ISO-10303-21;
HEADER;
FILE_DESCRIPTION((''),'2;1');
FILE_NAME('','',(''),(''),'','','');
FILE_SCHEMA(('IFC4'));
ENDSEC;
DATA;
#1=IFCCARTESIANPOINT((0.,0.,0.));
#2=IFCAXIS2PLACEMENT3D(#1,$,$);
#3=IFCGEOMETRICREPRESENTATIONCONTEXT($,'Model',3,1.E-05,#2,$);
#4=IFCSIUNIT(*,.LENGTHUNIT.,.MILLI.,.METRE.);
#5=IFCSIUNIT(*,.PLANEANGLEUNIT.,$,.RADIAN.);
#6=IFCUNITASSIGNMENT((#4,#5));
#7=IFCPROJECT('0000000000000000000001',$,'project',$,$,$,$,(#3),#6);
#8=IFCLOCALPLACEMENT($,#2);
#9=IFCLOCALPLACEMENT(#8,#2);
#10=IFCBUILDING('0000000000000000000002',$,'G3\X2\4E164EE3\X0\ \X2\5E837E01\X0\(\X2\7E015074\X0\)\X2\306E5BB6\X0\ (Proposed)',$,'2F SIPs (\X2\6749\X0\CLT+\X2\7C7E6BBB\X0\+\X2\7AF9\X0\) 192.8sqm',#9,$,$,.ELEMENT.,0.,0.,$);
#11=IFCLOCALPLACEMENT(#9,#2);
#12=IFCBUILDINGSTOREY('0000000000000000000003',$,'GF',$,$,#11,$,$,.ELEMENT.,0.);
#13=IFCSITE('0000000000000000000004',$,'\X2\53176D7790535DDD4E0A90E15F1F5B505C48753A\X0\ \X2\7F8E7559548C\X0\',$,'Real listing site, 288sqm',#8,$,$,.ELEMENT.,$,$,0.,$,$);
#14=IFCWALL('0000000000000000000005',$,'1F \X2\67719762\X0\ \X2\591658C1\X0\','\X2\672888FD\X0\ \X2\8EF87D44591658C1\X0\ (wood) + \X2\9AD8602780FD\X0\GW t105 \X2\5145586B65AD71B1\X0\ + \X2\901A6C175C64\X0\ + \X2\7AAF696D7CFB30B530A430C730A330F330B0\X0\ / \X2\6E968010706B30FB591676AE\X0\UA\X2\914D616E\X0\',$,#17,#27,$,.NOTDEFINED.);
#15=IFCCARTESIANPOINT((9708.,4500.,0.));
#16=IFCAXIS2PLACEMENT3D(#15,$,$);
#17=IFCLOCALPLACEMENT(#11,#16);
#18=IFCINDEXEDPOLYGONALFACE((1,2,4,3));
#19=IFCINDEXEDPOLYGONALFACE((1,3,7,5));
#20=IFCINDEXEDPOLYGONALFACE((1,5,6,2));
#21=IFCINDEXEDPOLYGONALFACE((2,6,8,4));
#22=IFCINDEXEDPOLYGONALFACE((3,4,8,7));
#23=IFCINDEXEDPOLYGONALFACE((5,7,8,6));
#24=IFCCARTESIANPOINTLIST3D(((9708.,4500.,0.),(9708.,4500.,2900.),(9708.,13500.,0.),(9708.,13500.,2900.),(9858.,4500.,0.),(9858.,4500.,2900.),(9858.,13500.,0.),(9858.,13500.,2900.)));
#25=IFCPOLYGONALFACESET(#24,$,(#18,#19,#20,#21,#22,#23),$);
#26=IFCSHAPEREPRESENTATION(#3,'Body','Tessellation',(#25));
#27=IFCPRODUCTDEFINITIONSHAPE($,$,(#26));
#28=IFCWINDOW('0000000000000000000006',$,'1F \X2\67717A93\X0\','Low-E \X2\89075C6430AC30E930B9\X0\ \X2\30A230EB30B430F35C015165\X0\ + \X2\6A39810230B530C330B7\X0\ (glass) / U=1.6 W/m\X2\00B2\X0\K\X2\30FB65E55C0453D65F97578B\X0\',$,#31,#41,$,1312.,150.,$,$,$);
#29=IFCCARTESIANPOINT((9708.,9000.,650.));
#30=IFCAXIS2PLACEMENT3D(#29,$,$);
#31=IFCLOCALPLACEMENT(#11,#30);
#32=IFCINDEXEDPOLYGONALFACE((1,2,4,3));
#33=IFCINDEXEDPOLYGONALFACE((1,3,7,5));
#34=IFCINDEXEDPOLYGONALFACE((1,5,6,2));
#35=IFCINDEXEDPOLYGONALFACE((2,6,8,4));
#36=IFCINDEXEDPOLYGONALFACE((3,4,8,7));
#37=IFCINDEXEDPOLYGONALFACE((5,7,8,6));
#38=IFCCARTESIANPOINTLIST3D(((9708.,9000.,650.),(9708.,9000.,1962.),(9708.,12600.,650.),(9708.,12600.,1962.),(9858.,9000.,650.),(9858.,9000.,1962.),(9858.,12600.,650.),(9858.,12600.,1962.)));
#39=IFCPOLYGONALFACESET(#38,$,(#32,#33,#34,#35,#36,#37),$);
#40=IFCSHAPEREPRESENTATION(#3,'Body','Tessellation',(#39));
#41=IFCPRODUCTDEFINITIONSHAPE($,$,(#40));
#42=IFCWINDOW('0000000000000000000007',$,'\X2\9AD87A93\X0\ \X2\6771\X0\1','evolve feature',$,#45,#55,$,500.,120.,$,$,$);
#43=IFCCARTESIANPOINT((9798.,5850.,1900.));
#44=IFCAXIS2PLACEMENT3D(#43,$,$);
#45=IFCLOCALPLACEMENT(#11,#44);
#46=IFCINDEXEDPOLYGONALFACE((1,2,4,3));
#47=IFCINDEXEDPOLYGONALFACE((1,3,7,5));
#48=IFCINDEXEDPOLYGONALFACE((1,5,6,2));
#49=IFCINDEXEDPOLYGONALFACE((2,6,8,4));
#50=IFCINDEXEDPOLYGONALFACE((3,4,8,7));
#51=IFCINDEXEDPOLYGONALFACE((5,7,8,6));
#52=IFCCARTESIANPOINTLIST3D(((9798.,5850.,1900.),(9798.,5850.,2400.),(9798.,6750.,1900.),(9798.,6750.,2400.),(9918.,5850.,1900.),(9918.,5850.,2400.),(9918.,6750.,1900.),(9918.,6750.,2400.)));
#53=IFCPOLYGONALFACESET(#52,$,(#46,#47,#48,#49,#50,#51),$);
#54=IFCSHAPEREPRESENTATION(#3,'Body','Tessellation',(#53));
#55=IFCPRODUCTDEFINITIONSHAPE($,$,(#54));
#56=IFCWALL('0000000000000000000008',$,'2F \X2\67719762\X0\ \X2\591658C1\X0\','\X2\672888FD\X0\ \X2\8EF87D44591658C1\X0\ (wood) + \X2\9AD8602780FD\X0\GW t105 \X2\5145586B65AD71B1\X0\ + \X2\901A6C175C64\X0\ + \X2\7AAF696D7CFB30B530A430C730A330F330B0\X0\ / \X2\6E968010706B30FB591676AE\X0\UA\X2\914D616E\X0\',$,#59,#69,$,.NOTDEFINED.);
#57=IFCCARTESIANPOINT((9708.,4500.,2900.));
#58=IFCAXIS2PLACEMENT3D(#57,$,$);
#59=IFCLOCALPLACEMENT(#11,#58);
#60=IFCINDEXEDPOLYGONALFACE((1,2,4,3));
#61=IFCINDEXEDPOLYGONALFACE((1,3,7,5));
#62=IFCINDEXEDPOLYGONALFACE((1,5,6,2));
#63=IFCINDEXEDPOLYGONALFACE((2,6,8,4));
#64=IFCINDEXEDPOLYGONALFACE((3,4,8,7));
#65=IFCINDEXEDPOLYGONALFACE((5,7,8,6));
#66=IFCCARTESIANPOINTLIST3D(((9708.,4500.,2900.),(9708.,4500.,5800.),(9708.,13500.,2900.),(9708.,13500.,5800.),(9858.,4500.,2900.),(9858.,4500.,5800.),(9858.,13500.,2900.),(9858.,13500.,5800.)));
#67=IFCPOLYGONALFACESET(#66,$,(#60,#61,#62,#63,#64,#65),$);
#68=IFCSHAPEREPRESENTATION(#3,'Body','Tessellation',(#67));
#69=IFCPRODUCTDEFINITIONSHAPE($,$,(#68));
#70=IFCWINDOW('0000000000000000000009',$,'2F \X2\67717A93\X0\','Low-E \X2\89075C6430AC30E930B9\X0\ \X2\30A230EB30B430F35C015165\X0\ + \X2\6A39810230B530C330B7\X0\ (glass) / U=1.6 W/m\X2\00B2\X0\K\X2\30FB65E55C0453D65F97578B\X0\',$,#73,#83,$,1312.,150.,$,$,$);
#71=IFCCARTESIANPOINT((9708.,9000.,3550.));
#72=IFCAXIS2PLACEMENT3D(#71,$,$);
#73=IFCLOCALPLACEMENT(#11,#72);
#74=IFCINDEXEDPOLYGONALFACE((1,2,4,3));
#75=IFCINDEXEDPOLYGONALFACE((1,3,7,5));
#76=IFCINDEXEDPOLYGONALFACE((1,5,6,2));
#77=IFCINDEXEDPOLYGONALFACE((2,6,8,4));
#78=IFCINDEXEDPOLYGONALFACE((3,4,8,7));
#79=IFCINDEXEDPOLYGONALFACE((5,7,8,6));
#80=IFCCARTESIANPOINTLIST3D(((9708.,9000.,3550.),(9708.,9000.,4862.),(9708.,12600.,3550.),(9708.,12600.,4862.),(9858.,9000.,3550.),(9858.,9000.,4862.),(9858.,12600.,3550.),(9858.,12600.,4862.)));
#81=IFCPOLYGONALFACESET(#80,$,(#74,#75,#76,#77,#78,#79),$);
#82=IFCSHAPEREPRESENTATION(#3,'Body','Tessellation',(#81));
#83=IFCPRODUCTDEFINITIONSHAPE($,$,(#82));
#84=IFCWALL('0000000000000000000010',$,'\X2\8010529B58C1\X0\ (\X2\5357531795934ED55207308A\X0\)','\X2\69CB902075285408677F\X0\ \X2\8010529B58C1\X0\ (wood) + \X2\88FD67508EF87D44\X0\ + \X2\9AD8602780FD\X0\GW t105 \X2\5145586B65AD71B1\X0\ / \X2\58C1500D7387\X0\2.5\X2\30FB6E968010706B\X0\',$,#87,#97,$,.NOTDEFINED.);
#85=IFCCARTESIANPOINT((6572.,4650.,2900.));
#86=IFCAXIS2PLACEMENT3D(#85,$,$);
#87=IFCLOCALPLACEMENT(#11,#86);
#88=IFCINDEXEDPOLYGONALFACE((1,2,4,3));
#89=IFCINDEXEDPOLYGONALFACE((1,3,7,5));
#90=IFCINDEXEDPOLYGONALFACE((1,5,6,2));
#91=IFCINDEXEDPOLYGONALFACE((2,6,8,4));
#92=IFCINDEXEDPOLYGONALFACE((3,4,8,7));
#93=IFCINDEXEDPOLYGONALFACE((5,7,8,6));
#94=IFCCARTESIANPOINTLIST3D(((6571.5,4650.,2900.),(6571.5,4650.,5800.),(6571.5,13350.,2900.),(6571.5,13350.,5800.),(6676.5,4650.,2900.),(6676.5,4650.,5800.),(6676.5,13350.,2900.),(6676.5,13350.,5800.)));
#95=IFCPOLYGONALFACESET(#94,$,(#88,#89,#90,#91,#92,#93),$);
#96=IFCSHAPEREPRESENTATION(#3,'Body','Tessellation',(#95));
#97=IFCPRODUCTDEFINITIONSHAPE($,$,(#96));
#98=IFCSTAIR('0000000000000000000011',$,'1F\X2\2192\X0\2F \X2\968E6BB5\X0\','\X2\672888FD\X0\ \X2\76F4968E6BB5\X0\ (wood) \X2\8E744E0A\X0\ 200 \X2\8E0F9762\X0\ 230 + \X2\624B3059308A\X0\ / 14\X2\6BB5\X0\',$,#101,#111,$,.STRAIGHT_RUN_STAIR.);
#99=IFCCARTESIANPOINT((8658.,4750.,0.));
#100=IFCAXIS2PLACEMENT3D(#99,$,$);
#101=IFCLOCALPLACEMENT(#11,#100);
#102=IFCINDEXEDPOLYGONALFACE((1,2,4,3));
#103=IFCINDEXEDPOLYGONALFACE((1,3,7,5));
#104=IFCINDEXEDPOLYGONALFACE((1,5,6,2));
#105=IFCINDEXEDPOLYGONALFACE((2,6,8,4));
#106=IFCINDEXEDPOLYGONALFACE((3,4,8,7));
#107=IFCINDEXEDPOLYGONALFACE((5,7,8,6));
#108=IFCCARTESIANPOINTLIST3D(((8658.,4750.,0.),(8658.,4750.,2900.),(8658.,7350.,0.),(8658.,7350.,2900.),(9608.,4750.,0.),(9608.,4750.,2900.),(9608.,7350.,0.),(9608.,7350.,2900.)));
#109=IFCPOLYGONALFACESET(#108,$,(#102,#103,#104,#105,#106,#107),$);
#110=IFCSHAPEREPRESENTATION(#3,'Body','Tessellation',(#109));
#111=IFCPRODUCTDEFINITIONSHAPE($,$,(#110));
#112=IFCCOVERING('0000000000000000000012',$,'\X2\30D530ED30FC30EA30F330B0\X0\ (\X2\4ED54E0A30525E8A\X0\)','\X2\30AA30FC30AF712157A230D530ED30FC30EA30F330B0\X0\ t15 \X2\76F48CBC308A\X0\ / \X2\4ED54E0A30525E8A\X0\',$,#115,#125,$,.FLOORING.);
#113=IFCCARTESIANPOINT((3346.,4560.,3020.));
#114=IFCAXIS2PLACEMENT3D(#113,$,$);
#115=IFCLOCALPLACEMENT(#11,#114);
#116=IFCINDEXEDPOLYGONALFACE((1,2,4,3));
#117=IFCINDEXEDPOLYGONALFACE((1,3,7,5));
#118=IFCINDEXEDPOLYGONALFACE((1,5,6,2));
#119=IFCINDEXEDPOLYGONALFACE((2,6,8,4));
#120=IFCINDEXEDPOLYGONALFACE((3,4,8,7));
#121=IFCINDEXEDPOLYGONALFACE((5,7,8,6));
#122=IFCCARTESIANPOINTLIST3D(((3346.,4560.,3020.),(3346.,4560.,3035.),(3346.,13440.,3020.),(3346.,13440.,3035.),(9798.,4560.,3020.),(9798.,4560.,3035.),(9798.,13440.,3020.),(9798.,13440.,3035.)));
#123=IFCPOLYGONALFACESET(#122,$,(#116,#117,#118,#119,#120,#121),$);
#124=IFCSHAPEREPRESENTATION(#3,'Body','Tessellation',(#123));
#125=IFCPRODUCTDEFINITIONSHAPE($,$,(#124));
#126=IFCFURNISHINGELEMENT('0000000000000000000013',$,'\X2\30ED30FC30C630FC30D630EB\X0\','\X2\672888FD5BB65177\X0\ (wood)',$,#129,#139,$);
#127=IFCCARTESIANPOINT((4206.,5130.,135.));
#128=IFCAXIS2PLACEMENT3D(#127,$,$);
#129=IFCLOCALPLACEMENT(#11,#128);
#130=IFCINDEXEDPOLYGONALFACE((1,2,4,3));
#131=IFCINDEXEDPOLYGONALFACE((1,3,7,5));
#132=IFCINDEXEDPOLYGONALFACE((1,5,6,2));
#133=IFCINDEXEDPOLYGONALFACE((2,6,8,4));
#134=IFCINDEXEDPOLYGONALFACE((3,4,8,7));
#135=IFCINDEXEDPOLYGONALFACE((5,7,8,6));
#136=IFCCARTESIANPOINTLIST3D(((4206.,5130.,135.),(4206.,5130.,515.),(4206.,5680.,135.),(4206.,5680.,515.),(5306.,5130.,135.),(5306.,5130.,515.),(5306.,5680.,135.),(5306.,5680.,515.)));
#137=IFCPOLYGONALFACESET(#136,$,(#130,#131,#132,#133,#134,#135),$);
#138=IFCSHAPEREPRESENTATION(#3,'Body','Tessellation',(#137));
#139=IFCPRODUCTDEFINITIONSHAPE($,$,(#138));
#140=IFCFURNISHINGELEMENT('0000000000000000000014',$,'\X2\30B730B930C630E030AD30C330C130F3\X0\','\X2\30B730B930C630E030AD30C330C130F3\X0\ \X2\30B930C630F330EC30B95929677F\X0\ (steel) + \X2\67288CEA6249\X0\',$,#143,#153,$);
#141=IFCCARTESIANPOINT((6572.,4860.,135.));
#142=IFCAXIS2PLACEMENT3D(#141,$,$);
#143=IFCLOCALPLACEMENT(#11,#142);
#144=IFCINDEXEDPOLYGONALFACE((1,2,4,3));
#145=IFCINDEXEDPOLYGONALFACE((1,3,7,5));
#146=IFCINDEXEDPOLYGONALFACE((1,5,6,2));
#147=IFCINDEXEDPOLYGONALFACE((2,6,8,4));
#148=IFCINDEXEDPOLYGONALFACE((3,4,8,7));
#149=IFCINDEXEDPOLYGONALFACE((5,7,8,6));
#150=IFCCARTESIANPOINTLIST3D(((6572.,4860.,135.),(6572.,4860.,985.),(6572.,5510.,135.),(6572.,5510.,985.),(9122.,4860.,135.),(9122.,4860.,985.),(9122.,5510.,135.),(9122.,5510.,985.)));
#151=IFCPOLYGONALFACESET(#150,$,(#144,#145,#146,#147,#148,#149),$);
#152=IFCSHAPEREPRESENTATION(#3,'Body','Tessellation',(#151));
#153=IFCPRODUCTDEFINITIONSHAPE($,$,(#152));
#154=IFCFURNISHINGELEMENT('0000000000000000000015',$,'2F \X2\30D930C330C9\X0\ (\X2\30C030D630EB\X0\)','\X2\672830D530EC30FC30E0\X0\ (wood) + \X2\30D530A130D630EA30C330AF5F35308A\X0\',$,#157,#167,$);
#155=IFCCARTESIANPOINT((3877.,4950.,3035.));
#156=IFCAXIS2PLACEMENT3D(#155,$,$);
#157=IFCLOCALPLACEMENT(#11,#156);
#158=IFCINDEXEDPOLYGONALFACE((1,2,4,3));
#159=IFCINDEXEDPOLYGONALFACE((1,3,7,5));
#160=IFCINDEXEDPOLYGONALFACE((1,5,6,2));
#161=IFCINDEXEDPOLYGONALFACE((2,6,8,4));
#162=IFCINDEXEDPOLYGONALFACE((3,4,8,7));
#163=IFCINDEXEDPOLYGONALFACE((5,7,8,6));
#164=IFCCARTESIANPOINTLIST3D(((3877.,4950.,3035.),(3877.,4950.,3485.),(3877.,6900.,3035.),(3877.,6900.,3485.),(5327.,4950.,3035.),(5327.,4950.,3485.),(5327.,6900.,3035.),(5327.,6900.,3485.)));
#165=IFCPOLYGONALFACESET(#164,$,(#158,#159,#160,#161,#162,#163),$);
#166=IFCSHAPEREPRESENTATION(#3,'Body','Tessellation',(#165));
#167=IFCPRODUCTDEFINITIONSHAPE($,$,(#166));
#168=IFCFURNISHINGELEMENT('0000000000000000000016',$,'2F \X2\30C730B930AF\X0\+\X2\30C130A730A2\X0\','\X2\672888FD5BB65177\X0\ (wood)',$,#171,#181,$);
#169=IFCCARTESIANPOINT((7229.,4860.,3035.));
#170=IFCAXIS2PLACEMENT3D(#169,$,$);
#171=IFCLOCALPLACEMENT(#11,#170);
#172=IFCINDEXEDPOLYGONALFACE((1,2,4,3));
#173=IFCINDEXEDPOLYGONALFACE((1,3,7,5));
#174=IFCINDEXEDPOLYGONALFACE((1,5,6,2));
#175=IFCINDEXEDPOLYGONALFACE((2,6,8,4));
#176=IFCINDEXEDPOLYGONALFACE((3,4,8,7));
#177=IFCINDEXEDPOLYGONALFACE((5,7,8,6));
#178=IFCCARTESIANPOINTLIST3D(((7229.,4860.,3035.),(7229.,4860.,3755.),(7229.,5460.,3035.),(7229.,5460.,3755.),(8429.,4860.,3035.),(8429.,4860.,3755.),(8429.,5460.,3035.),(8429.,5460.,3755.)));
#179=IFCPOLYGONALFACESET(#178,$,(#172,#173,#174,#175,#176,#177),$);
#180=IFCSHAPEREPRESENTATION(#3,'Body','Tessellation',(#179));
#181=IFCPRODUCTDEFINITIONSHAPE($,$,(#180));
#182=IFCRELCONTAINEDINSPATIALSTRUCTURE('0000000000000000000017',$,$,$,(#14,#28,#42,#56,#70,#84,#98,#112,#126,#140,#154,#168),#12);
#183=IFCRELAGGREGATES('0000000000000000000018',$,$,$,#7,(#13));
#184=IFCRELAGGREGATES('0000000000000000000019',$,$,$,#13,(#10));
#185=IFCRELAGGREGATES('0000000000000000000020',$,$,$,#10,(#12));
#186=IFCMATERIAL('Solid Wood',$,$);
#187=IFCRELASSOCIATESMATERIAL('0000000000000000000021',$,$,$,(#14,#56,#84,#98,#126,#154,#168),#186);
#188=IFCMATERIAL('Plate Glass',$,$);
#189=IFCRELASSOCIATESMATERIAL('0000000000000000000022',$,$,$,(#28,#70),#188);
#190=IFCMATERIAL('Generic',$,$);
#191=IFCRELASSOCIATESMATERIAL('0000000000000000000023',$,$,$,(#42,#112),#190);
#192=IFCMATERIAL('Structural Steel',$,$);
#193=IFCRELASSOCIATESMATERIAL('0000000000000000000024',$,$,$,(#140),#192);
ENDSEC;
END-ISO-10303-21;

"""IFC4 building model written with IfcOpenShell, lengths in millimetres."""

from ifc_helpers import new_model, si_unit, frame, frame_2d, origin, place, context, project, spatial, rectangle, extrude, material, element, fill, save


model = new_model("IFC4")

# Units and contexts
model_context = context("Model", 3, precision=1e-05, world=origin())
ifc_project = project(units=[si_unit("LENGTHUNIT", "METRE", prefix="MILLI"), si_unit("PLANEANGLEUNIT", "RADIAN")], contexts=[model_context])

# Site, building, storey
site_placement = place(None, origin())
site = spatial("IfcSite", under=ifc_project, at=site_placement, Name="北海道川上郡弟子屈町 美留和", ObjectType="Real listing site, 288sqm", CompositionType="ELEMENT", RefElevation=0.0)
building_placement = place(site_placement, origin())
building = spatial("IfcBuilding", under=site, at=building_placement, Name="G3世代 広縁(縁側)の家 (Proposed)", ObjectType="2F SIPs (杉CLT+籾殻+竹) 192.8sqm", CompositionType="ELEMENT", ElevationOfRefHeight=0.0, ElevationOfTerrain=0.0)
storey_placement = place(building_placement, origin())
storey = spatial("IfcBuildingStorey", under=building, at=storey_placement, Name="GF", CompositionType="ELEMENT", Elevation=0.0)

# Shared definitions
ifc_material_1 = material(Name="Solid Wood")

# Wall, openings, windows
wall_1_placement = place(storey_placement, frame((9708.0, 4500.0, 0.0)))
wall_1 = element("IfcWall", 1, at=wall_1_placement, inside=storey, material=ifc_material_1, Name="1F 東面 外壁", Description="木製 軸組外壁 (wood) + 高性能GW t105 充填断熱 + 通気層 + 窯業系サイディング / 準耐火・外皮UA配慮", PredefinedType="NOTDEFINED", context=model_context, shape_type="SweptSolid", body=[
    extrude(rectangle(XDim=150.0, YDim=9000.0, at=frame_2d((75.0, 4500.0))), frame((9708.0, 4500.0, 0.0)), (0.0, 0.0, 1.0), 2900.0),
])
opening_1_placement = place(storey_placement, frame((9708.0, 9000.0, 650.0)))
opening_1 = element("IfcOpeningElement", 2, at=opening_1_placement, cuts=wall_1, PredefinedType="NOTDEFINED", context=model_context, shape_type="SweptSolid", body=[
    extrude(rectangle(XDim=150.0, YDim=3600.0, at=frame_2d((75.0, 1800.0))), frame((9708.0, 9000.0, 650.0)), (0.0, 0.0, 1.0), 1312.0),
])
opening_2_placement = place(storey_placement, frame((9798.0, 5850.0, 1900.0)))
opening_2 = element("IfcOpeningElement", 3, at=opening_2_placement, cuts=wall_1, PredefinedType="NOTDEFINED", context=model_context, shape_type="SweptSolid", body=[
    extrude(rectangle(XDim=120.0, YDim=900.0, at=frame_2d((60.0, 450.0))), frame((9798.0, 5850.0, 1900.0)), (0.0, 0.0, 1.0), 500.0),
])
ifc_material_2 = material(Name="Plate Glass")
window_1_placement = place(storey_placement, frame((9708.0, 9000.0, 650.0)))
window_1 = element("IfcWindow", 4, at=window_1_placement, inside=storey, material=ifc_material_2, Name="1F 東窓", Description="Low-E 複層ガラス アルゴン封入 + 樹脂サッシ (glass) / U=1.6 W/m²K・日射取得型", OverallHeight=1312.0, OverallWidth=150.0, context=model_context, shape_type="SweptSolid", body=[
    extrude(rectangle(XDim=150.0, YDim=3600.0, at=frame_2d((75.0, 1800.0))), frame((9708.0, 9000.0, 650.0)), (0.0, 0.0, 1.0), 1312.0),
])
fill(opening_1, window_1)
ifc_material_3 = material(Name="Generic")
window_2_placement = place(storey_placement, frame((9798.0, 5850.0, 1900.0)))
window_2 = element("IfcWindow", 5, at=window_2_placement, inside=storey, material=ifc_material_3, Name="高窓 東1", Description="evolve feature", OverallHeight=500.0, OverallWidth=120.0, context=model_context, shape_type="SweptSolid", body=[
    extrude(rectangle(XDim=120.0, YDim=900.0, at=frame_2d((60.0, 450.0))), frame((9798.0, 5850.0, 1900.0)), (0.0, 0.0, 1.0), 500.0),
])
fill(opening_2, window_2)

# Wall, opening, window
wall_2_placement = place(storey_placement, frame((9708.0, 4500.0, 2900.0)))
wall_2 = element("IfcWall", 6, at=wall_2_placement, inside=storey, material=ifc_material_1, Name="2F 東面 外壁", Description="木製 軸組外壁 (wood) + 高性能GW t105 充填断熱 + 通気層 + 窯業系サイディング / 準耐火・外皮UA配慮", PredefinedType="NOTDEFINED", context=model_context, shape_type="SweptSolid", body=[
    extrude(rectangle(XDim=150.0, YDim=9000.0, at=frame_2d((75.0, 4500.0))), frame((9708.0, 4500.0, 2900.0)), (0.0, 0.0, 1.0), 2900.0),
])
opening_3_placement = place(storey_placement, frame((9708.0, 9000.0, 3550.0)))
opening_3 = element("IfcOpeningElement", 7, at=opening_3_placement, cuts=wall_2, PredefinedType="NOTDEFINED", context=model_context, shape_type="SweptSolid", body=[
    extrude(rectangle(XDim=150.0, YDim=3600.0, at=frame_2d((75.0, 1800.0))), frame((9708.0, 9000.0, 3550.0)), (0.0, 0.0, 1.0), 1312.0),
])
window_3_placement = place(storey_placement, frame((9708.0, 9000.0, 3550.0)))
window_3 = element("IfcWindow", 8, at=window_3_placement, inside=storey, material=ifc_material_2, Name="2F 東窓", Description="Low-E 複層ガラス アルゴン封入 + 樹脂サッシ (glass) / U=1.6 W/m²K・日射取得型", OverallHeight=1312.0, OverallWidth=150.0, context=model_context, shape_type="SweptSolid", body=[
    extrude(rectangle(XDim=150.0, YDim=3600.0, at=frame_2d((75.0, 1800.0))), frame((9708.0, 9000.0, 3550.0)), (0.0, 0.0, 1.0), 1312.0),
])
fill(opening_3, window_3)

# Wall
wall_3_placement = place(storey_placement, frame((6572.0, 4650.0, 2900.0)))
element("IfcWall", 9, at=wall_3_placement, inside=storey, material=ifc_material_1, Name="耐力壁 (南北間仕切り)", Description="構造用合板 耐力壁 (wood) + 製材軸組 + 高性能GW t105 充填断熱 / 壁倍率2.5・準耐火", PredefinedType="NOTDEFINED", context=model_context, shape_type="SweptSolid", body=[
    extrude(rectangle(XDim=105.0, YDim=8700.0, at=frame_2d((52.0, 4350.0))), frame((6572.0, 4650.0, 2900.0)), (0.0, 0.0, 1.0), 2900.0),
])

# Stair
stair_placement = place(storey_placement, frame((8658.0, 4750.0, 0.0)))
element("IfcStair", 10, at=stair_placement, inside=storey, material=ifc_material_1, Name="1F→2F 階段", Description="木製 直階段 (wood) 蹴上 200 踏面 230 + 手すり / 14段", PredefinedType="STRAIGHT_RUN_STAIR", context=model_context, shape_type="SweptSolid", body=[
    extrude(rectangle(XDim=950.0, YDim=2600.0, at=frame_2d((475.0, 1300.0))), frame((8658.0, 4750.0, 0.0)), (0.0, 0.0, 1.0), 2900.0),
])

# Covering
covering_placement = place(storey_placement, frame((3346.0, 4560.0, 3020.0)))
element("IfcCovering", 11, at=covering_placement, inside=storey, material=ifc_material_3, Name="フローリング (仕上げ床)", Description="オーク無垢フローリング t15 直貼り / 仕上げ床", PredefinedType="FLOORING", context=model_context, shape_type="SweptSolid", body=[
    extrude(rectangle(XDim=6452.0, YDim=8880.0, at=frame_2d((3226.0, 4440.0))), frame((3346.0, 4560.0, 3020.0)), (0.0, 0.0, 1.0), 15.0),
])

# Furnishing elements
furnishing_1_placement = place(storey_placement, frame((4206.0, 5130.0, 135.0)))
element("IfcFurnishingElement", 12, at=furnishing_1_placement, inside=storey, material=ifc_material_1, Name="ローテーブル", Description="木製家具 (wood)", context=model_context, shape_type="SweptSolid", body=[
    extrude(rectangle(XDim=1100.0, YDim=550.0, at=frame_2d((550.0, 275.0))), frame((4206.0, 5130.0, 135.0)), (0.0, 0.0, 1.0), 380.0),
])
ifc_material_4 = material(Name="Structural Steel")
furnishing_2_placement = place(storey_placement, frame((6572.0, 4860.0, 135.0)))
element("IfcFurnishingElement", 13, at=furnishing_2_placement, inside=storey, material=ifc_material_4, Name="システムキッチン", Description="システムキッチン ステンレス天板 (steel) + 木質扉", context=model_context, shape_type="SweptSolid", body=[
    extrude(rectangle(XDim=2550.0, YDim=650.0, at=frame_2d((1275.0, 325.0))), frame((6572.0, 4860.0, 135.0)), (0.0, 0.0, 1.0), 850.0),
])
furnishing_3_placement = place(storey_placement, frame((3877.0, 4950.0, 3035.0)))
element("IfcFurnishingElement", 14, at=furnishing_3_placement, inside=storey, material=ifc_material_1, Name="2F ベッド (ダブル)", Description="木フレーム (wood) + ファブリック張り", context=model_context, shape_type="SweptSolid", body=[
    extrude(rectangle(XDim=1450.0, YDim=1950.0, at=frame_2d((725.0, 975.0))), frame((3877.0, 4950.0, 3035.0)), (0.0, 0.0, 1.0), 450.0),
])
furnishing_4_placement = place(storey_placement, frame((7229.0, 4860.0, 3035.0)))
element("IfcFurnishingElement", 15, at=furnishing_4_placement, inside=storey, material=ifc_material_1, Name="2F デスク+チェア", Description="木製家具 (wood)", context=model_context, shape_type="SweptSolid", body=[
    extrude(rectangle(XDim=1200.0, YDim=600.0, at=frame_2d((600.0, 300.0))), frame((7229.0, 4860.0, 3035.0)), (0.0, 0.0, 1.0), 720.0),
])

save(model, "model.ifc")
